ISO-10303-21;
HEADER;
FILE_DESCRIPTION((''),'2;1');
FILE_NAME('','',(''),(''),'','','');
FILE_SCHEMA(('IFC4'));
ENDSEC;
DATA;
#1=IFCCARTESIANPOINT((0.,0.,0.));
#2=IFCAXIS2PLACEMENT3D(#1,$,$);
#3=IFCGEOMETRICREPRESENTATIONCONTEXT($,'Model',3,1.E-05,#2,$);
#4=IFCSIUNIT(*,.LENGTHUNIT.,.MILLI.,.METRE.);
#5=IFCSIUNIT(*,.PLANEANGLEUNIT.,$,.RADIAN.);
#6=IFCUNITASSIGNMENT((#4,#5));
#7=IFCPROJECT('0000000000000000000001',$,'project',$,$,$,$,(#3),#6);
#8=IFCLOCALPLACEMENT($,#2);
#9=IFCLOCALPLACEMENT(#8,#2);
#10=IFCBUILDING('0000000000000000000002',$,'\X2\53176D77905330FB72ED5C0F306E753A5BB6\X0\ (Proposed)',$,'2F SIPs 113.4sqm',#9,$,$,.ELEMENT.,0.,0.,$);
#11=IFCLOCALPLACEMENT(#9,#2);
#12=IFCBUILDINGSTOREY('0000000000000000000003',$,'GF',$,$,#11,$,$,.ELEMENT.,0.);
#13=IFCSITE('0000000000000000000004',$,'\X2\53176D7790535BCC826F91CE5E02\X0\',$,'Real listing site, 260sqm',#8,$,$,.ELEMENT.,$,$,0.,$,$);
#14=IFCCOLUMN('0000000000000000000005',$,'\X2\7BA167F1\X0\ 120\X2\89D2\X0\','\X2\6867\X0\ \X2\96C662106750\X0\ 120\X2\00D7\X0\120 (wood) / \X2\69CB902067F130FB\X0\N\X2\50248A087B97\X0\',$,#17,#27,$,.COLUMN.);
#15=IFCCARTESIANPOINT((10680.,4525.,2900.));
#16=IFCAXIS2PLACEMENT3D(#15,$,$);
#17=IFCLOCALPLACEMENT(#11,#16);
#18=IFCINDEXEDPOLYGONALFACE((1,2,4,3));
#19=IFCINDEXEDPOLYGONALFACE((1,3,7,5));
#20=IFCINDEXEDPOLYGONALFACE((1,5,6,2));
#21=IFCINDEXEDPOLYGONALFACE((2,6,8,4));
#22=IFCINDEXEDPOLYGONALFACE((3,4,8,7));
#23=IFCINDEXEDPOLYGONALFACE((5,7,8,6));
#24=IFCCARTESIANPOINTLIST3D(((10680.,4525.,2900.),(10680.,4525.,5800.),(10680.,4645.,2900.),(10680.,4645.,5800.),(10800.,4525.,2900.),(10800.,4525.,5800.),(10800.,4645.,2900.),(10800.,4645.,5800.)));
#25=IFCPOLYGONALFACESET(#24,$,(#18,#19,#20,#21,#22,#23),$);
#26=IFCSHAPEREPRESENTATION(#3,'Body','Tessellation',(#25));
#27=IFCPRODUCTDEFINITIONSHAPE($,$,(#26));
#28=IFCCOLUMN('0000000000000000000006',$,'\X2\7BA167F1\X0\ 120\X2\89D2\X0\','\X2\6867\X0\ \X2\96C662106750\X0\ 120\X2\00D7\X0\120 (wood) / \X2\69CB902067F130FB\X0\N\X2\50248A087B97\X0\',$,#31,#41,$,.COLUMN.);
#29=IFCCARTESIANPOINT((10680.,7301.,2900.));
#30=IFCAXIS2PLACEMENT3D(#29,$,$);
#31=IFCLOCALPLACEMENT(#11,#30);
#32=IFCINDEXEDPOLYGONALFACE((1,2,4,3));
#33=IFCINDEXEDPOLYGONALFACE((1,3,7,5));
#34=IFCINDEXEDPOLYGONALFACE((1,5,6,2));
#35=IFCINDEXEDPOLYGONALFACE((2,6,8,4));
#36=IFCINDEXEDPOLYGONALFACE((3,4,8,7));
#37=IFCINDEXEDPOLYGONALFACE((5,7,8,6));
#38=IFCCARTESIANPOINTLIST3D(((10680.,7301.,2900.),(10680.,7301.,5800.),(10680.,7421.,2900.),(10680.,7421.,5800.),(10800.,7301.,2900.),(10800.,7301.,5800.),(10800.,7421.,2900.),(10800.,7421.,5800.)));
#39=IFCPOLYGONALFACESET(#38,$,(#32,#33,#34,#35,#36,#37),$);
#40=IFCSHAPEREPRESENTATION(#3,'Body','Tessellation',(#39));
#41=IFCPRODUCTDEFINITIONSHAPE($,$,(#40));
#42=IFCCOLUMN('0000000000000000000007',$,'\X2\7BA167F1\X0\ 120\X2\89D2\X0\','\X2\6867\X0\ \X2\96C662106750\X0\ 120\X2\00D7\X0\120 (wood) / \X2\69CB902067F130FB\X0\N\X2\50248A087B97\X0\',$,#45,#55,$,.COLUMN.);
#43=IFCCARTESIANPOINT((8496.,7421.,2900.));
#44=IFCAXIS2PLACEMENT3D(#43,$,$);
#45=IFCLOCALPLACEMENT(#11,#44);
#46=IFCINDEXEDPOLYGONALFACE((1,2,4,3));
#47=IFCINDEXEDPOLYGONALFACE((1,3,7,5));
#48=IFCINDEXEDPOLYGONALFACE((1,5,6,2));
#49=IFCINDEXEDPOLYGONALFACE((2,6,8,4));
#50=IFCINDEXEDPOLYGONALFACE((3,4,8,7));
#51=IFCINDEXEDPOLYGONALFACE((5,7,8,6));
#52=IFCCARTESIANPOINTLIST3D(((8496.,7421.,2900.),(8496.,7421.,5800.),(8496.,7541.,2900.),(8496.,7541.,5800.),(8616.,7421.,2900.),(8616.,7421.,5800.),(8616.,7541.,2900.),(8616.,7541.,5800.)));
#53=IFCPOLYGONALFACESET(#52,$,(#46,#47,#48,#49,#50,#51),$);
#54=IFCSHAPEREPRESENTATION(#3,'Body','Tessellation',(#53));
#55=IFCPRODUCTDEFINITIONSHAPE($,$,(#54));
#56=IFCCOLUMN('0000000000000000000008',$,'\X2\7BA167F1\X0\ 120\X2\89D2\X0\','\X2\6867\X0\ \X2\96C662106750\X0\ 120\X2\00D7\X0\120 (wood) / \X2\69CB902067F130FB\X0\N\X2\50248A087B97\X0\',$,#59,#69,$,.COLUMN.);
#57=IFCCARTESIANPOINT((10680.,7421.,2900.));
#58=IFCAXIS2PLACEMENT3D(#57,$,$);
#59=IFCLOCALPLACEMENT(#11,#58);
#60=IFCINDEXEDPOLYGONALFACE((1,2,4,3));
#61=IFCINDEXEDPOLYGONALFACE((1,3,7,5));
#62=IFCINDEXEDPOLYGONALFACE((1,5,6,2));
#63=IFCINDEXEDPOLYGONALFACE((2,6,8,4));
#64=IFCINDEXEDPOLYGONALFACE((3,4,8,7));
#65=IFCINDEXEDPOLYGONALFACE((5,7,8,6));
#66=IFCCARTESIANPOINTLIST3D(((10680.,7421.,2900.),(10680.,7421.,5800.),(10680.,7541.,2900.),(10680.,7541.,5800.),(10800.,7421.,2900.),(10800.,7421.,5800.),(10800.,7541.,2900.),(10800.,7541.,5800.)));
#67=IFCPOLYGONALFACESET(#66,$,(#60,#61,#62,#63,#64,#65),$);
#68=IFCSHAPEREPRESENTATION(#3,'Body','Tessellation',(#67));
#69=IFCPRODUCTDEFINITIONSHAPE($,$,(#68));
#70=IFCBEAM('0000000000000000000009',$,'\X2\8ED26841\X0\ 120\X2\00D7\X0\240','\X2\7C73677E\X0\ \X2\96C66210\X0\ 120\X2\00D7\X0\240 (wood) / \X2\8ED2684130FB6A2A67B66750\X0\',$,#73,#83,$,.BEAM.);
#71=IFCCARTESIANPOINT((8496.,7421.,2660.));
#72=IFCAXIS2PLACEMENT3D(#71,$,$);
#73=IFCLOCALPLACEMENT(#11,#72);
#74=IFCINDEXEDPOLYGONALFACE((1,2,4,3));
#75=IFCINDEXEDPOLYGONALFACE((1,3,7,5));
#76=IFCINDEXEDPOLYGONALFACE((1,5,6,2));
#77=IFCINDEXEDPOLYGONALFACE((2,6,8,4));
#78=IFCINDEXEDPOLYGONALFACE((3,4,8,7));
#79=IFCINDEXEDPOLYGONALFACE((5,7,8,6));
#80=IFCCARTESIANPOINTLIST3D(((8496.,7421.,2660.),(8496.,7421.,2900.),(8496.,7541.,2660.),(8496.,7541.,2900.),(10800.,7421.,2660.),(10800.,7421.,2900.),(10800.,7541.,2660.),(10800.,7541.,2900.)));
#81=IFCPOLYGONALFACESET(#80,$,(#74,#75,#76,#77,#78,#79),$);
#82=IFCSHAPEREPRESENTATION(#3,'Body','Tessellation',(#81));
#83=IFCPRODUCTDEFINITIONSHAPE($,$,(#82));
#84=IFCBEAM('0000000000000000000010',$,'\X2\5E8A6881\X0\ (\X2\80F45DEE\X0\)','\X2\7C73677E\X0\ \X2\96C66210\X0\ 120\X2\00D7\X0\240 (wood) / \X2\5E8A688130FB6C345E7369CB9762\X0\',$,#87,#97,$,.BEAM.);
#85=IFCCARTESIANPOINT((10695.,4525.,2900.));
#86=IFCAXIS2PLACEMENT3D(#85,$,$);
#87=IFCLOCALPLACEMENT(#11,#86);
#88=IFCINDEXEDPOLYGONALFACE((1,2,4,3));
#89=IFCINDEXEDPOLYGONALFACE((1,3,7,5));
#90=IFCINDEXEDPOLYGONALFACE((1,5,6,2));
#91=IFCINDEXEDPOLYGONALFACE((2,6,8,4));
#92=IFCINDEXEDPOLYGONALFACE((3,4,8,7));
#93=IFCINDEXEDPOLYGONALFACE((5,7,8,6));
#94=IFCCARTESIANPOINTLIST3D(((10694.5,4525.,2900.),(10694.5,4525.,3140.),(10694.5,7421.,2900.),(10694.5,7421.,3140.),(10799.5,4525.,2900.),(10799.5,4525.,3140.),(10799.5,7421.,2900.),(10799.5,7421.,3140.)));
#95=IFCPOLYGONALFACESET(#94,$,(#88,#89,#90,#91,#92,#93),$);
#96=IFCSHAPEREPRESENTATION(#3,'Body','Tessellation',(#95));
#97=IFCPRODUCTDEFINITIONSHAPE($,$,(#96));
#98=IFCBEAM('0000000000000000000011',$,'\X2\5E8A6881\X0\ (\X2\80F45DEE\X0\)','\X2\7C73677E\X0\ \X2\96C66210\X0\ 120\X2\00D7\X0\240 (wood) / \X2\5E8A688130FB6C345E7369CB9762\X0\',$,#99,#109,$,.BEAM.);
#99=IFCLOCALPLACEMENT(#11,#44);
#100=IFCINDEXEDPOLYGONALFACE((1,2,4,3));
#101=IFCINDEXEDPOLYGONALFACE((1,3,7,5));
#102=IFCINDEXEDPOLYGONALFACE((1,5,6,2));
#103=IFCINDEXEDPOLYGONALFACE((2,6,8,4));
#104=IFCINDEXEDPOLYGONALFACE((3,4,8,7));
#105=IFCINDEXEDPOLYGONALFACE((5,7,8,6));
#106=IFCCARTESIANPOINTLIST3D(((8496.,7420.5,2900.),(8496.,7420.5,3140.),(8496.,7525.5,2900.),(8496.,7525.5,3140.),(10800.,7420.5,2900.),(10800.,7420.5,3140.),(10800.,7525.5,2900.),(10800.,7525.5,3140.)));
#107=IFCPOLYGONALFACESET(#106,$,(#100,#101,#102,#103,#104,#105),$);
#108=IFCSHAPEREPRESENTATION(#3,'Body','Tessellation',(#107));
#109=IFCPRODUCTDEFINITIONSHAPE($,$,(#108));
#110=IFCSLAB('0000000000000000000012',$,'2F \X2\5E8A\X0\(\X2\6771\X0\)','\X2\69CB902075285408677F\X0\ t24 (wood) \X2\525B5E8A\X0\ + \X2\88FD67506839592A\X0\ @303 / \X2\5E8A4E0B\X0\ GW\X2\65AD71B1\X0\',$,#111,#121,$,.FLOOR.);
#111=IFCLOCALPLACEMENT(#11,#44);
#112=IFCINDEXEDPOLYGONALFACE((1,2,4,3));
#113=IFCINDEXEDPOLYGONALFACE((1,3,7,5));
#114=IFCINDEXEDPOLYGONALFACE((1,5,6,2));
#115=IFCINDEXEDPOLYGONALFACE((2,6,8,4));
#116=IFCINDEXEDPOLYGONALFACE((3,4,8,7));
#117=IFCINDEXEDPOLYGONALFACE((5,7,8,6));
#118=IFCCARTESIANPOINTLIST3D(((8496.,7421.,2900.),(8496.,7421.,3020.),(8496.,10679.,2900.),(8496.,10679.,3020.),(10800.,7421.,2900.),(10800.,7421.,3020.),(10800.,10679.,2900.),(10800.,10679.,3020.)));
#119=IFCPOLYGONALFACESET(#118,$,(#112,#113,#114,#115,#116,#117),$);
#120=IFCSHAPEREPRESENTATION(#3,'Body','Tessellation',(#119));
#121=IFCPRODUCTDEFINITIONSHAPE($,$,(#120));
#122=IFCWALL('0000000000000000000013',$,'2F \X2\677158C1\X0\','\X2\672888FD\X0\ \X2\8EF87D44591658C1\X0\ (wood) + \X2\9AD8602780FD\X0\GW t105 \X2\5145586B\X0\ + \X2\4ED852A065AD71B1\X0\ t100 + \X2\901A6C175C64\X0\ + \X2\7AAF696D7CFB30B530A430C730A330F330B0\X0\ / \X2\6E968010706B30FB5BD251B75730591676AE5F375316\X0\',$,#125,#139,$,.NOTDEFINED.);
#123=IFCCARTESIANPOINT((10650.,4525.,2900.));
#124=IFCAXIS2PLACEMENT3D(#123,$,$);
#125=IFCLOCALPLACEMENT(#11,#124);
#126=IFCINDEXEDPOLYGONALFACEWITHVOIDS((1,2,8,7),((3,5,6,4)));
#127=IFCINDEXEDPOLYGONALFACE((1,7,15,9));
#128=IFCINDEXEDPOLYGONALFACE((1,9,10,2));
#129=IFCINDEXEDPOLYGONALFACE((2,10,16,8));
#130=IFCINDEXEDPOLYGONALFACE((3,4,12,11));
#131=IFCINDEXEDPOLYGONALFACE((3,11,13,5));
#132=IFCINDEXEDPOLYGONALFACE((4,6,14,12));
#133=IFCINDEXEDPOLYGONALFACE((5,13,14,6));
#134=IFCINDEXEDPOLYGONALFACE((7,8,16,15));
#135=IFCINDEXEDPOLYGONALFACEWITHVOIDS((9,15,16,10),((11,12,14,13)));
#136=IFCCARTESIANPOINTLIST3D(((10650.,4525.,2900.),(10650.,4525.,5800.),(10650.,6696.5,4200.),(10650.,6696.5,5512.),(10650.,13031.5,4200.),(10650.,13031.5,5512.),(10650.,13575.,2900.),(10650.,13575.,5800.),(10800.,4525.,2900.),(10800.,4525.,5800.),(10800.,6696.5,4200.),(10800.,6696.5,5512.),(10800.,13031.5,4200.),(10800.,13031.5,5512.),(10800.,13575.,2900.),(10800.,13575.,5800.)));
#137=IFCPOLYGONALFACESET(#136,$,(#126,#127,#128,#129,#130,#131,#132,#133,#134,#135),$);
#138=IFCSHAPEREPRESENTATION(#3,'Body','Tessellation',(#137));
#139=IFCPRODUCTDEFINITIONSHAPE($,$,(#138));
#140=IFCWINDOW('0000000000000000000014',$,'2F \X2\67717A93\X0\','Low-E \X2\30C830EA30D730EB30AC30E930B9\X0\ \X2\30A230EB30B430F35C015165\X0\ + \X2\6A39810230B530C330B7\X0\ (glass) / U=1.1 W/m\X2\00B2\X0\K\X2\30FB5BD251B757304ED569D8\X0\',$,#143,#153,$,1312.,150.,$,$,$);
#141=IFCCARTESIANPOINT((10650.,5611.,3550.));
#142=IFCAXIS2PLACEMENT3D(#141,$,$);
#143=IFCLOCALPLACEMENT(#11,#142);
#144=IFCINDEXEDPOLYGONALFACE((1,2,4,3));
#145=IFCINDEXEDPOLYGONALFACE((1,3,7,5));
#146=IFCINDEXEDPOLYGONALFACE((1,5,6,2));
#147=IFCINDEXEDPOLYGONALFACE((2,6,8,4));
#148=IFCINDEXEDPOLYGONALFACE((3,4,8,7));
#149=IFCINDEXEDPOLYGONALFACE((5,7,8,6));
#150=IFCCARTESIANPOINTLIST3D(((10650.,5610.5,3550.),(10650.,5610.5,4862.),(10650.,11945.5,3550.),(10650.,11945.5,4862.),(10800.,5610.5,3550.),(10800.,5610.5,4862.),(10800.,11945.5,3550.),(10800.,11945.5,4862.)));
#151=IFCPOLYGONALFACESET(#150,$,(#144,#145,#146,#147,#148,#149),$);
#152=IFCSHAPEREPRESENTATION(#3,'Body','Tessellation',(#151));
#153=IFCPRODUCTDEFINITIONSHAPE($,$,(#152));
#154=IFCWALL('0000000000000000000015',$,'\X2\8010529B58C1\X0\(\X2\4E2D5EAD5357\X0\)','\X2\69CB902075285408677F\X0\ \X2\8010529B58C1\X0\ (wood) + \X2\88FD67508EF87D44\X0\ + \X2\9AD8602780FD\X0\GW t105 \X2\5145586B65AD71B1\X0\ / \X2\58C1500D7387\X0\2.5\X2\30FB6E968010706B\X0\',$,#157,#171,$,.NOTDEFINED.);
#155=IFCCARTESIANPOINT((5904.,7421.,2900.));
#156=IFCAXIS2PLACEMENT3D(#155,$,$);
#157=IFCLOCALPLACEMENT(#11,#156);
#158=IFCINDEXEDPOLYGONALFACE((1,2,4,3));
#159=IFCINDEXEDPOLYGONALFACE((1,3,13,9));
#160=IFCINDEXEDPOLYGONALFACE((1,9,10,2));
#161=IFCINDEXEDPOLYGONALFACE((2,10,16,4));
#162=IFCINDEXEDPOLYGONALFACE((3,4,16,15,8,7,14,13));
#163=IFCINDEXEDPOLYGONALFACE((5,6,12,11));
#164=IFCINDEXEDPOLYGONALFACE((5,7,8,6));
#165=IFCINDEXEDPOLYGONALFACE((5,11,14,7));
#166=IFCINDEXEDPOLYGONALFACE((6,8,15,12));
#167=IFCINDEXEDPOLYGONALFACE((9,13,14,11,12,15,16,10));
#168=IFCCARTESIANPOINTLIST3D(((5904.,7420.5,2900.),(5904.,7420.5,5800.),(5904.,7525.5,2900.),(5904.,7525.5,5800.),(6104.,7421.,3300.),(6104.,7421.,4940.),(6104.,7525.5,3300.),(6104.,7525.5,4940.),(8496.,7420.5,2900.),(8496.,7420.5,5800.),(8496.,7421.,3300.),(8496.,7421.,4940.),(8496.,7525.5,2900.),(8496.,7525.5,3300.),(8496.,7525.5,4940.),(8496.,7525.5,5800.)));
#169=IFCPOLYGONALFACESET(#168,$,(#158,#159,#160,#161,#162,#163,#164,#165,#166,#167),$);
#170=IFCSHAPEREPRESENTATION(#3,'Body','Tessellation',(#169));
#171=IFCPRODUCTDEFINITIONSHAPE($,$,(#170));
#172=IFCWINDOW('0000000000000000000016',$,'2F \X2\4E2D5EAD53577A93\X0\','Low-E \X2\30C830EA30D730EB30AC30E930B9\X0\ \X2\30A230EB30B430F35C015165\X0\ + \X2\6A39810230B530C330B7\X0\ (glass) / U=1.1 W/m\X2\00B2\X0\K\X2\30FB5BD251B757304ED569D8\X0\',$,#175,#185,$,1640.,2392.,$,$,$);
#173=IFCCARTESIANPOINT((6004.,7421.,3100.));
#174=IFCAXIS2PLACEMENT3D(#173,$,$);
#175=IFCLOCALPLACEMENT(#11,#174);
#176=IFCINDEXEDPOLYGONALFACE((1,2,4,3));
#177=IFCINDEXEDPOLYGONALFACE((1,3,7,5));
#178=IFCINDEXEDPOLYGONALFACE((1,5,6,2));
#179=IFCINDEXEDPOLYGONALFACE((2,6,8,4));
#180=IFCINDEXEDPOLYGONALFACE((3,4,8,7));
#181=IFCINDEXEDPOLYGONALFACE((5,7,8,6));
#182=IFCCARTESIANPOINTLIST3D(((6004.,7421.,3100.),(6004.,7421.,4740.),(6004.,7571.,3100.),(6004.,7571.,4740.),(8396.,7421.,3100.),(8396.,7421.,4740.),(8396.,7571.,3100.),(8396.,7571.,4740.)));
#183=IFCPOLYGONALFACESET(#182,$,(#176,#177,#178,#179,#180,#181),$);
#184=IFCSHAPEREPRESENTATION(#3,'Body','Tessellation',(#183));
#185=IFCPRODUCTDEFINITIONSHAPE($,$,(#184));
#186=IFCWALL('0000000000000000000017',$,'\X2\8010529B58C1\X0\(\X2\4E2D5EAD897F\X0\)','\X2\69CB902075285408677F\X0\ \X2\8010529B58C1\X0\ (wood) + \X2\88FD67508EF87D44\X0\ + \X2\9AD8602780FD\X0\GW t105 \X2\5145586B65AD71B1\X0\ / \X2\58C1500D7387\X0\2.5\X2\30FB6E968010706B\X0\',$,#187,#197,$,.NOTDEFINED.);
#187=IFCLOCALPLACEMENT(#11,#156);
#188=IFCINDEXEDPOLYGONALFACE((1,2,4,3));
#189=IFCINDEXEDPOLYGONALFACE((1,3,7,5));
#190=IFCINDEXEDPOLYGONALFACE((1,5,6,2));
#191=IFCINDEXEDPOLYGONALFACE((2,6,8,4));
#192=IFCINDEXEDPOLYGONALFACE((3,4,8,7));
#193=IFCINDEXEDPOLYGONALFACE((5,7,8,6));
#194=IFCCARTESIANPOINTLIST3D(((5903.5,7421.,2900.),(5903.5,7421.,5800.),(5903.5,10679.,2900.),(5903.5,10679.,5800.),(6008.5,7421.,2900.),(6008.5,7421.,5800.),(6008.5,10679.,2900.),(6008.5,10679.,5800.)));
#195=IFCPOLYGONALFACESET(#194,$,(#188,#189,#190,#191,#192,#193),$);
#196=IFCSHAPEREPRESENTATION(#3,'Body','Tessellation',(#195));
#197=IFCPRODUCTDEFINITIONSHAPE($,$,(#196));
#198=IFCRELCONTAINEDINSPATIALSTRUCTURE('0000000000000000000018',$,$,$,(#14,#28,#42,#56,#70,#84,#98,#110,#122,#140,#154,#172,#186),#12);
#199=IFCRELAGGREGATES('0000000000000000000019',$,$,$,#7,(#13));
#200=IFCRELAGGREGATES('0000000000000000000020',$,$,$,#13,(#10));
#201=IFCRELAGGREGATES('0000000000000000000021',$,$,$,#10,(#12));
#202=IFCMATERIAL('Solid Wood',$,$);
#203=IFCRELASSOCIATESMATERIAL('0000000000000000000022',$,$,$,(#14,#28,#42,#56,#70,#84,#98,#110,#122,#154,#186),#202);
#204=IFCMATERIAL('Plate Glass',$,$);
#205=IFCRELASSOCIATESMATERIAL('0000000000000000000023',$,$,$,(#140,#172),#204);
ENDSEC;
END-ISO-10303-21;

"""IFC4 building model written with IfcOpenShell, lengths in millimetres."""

from ifc_helpers import new_model, si_unit, frame, frame_2d, origin, place, context, project, spatial, rectangle, extrude, material, element, fill, save


model = new_model("IFC4")

# Units and contexts
model_context = context("Model", 3, precision=1e-05, world=origin())
ifc_project = project(units=[si_unit("LENGTHUNIT", "METRE", prefix="MILLI"), si_unit("PLANEANGLEUNIT", "RADIAN")], contexts=[model_context])

# Site, building, storey
site_placement = place(None, origin())
site = spatial("IfcSite", under=ifc_project, at=site_placement, Name="北海道富良野市", ObjectType="Real listing site, 260sqm", CompositionType="ELEMENT", RefElevation=0.0)
building_placement = place(site_placement, origin())
building = spatial("IfcBuilding", under=site, at=building_placement, Name="北海道・狭小の町家 (Proposed)", ObjectType="2F SIPs 113.4sqm", CompositionType="ELEMENT", ElevationOfRefHeight=0.0, ElevationOfTerrain=0.0)
storey_placement = place(building_placement, origin())
storey = spatial("IfcBuildingStorey", under=building, at=storey_placement, Name="GF", CompositionType="ELEMENT", Elevation=0.0)

# Columns
ifc_material_1 = material(Name="Solid Wood")
column_1_placement = place(storey_placement, frame((10680.0, 4525.0, 2900.0)))
element("IfcColumn", 1, at=column_1_placement, inside=storey, material=ifc_material_1, Name="管柱 120角", Description="桧 集成材 120×120 (wood) / 構造柱・N値計算", PredefinedType="COLUMN", context=model_context, shape_type="SweptSolid", body=[
    extrude(rectangle(XDim=120.0, YDim=120.0, at=frame_2d((60.0, 60.0))), frame((10680.0, 4525.0, 2900.0)), (0.0, 0.0, 1.0), 2900.0),
])
column_2_placement = place(storey_placement, frame((10680.0, 7301.0, 2900.0)))
element("IfcColumn", 2, at=column_2_placement, inside=storey, material=ifc_material_1, Name="管柱 120角", Description="桧 集成材 120×120 (wood) / 構造柱・N値計算", PredefinedType="COLUMN", context=model_context, shape_type="SweptSolid", body=[
    extrude(rectangle(XDim=120.0, YDim=120.0, at=frame_2d((60.0, 60.0))), frame((10680.0, 7301.0, 2900.0)), (0.0, 0.0, 1.0), 2900.0),
])
column_3_placement = place(storey_placement, frame((8496.0, 7421.0, 2900.0)))
element("IfcColumn", 3, at=column_3_placement, inside=storey, material=ifc_material_1, Name="管柱 120角", Description="桧 集成材 120×120 (wood) / 構造柱・N値計算", PredefinedType="COLUMN", context=model_context, shape_type="SweptSolid", body=[
    extrude(rectangle(XDim=120.0, YDim=120.0, at=frame_2d((60.0, 60.0))), frame((8496.0, 7421.0, 2900.0)), (0.0, 0.0, 1.0), 2900.0),
])
column_4_placement = place(storey_placement, frame((10680.0, 7421.0, 2900.0)))
element("IfcColumn", 4, at=column_4_placement, inside=storey, material=ifc_material_1, Name="管柱 120角", Description="桧 集成材 120×120 (wood) / 構造柱・N値計算", PredefinedType="COLUMN", context=model_context, shape_type="SweptSolid", body=[
    extrude(rectangle(XDim=120.0, YDim=120.0, at=frame_2d((60.0, 60.0))), frame((10680.0, 7421.0, 2900.0)), (0.0, 0.0, 1.0), 2900.0),
])

# Beams
beam_1_placement = place(storey_placement, frame((8496.0, 7421.0, 2660.0)))
element("IfcBeam", 5, at=beam_1_placement, inside=storey, material=ifc_material_1, Name="軒桁 120×240", Description="米松 集成 120×240 (wood) / 軒桁・横架材", PredefinedType="BEAM", context=model_context, shape_type="SweptSolid", body=[
    extrude(rectangle(XDim=2304.0, YDim=120.0, at=frame_2d((1152.0, 60.0))), frame((8496.0, 7421.0, 2660.0)), (0.0, 0.0, 1.0), 240.0),
])
beam_2_placement = place(storey_placement, frame((10695.0, 4525.0, 2900.0)))
element("IfcBeam", 6, at=beam_2_placement, inside=storey, material=ifc_material_1, Name="床梁 (胴差)", Description="米松 集成 120×240 (wood) / 床梁・水平構面", PredefinedType="BEAM", context=model_context, shape_type="SweptSolid", body=[
    extrude(rectangle(XDim=105.0, YDim=2896.0, at=frame_2d((52.0, 1448.0))), frame((10695.0, 4525.0, 2900.0)), (0.0, 0.0, 1.0), 240.0),
])
beam_3_placement = place(storey_placement, frame((8496.0, 7421.0, 2900.0)))
element("IfcBeam", 7, at=beam_3_placement, inside=storey, material=ifc_material_1, Name="床梁 (胴差)", Description="米松 集成 120×240 (wood) / 床梁・水平構面", PredefinedType="BEAM", context=model_context, shape_type="SweptSolid", body=[
    extrude(rectangle(XDim=2304.0, YDim=105.0, at=frame_2d((1152.0, 52.0))), frame((8496.0, 7421.0, 2900.0)), (0.0, 0.0, 1.0), 240.0),
])

# Slab
slab_placement = place(storey_placement, frame((8496.0, 7421.0, 2900.0)))
element("IfcSlab", 8, at=slab_placement, inside=storey, material=ifc_material_1, Name="2F 床(東)", Description="構造用合板 t24 (wood) 剛床 + 製材根太 @303 / 床下 GW断熱", PredefinedType="FLOOR", context=model_context, shape_type="SweptSolid", body=[
    extrude(rectangle(XDim=2304.0, YDim=3258.0, at=frame_2d((1152.0, 1629.0))), frame((8496.0, 7421.0, 2900.0)), (0.0, 0.0, 1.0), 120.0),
])

# Walls, openings, windows
wall_1_placement = place(storey_placement, frame((10650.0, 4525.0, 2900.0)))
wall_1 = element("IfcWall", 9, at=wall_1_placement, inside=storey, material=ifc_material_1, Name="2F 東壁", Description="木製 軸組外壁 (wood) + 高性能GW t105 充填 + 付加断熱 t100 + 通気層 + 窯業系サイディング / 準耐火・寒冷地外皮強化", PredefinedType="NOTDEFINED", context=model_context, shape_type="SweptSolid", body=[
    extrude(rectangle(XDim=150.0, YDim=9050.0, at=frame_2d((75.0, 4525.0))), frame((10650.0, 4525.0, 2900.0)), (0.0, 0.0, 1.0), 2900.0),
])
opening_1_placement = place(storey_placement, frame((10650.0, 5611.0, 3550.0)))
opening_1 = element("IfcOpeningElement", 10, at=opening_1_placement, cuts=wall_1, PredefinedType="NOTDEFINED", context=model_context, shape_type="SweptSolid", body=[
    extrude(rectangle(XDim=150.0, YDim=6335.0, at=frame_2d((75.0, 3167.0))), frame((10650.0, 5611.0, 3550.0)), (0.0, 0.0, 1.0), 1312.0),
])
ifc_material_2 = material(Name="Plate Glass")
window_1_placement = place(storey_placement, frame((10650.0, 5611.0, 3550.0)))
window_1 = element("IfcWindow", 11, at=window_1_placement, inside=storey, material=ifc_material_2, Name="2F 東窓", Description="Low-E トリプルガラス アルゴン封入 + 樹脂サッシ (glass) / U=1.1 W/m²K・寒冷地仕様", OverallHeight=1312.0, OverallWidth=150.0, context=model_context, shape_type="SweptSolid", body=[
    extrude(rectangle(XDim=150.0, YDim=6335.0, at=frame_2d((75.0, 3167.0))), frame((10650.0, 5611.0, 3550.0)), (0.0, 0.0, 1.0), 1312.0),
])
fill(opening_1, window_1)
wall_2_placement = place(storey_placement, frame((5904.0, 7421.0, 2900.0)))
wall_2 = element("IfcWall", 12, at=wall_2_placement, inside=storey, material=ifc_material_1, Name="耐力壁(中庭南)", Description="構造用合板 耐力壁 (wood) + 製材軸組 + 高性能GW t105 充填断熱 / 壁倍率2.5・準耐火", PredefinedType="NOTDEFINED", context=model_context, shape_type="SweptSolid", body=[
    extrude(rectangle(XDim=2592.0, YDim=105.0, at=frame_2d((1296.0, 52.0))), frame((5904.0, 7421.0, 2900.0)), (0.0, 0.0, 1.0), 2900.0),
])
opening_2_placement = place(storey_placement, frame((6004.0, 7421.0, 3100.0)))
opening_2 = element("IfcOpeningElement", 13, at=opening_2_placement, cuts=wall_2, PredefinedType="NOTDEFINED", context=model_context, shape_type="SweptSolid", body=[
    extrude(rectangle(XDim=2392.0, YDim=150.0, at=frame_2d((1196.0, 75.0))), frame((6004.0, 7421.0, 3100.0)), (0.0, 0.0, 1.0), 1640.0),
])
window_2_placement = place(storey_placement, frame((6004.0, 7421.0, 3100.0)))
window_2 = element("IfcWindow", 14, at=window_2_placement, inside=storey, material=ifc_material_2, Name="2F 中庭南窓", Description="Low-E トリプルガラス アルゴン封入 + 樹脂サッシ (glass) / U=1.1 W/m²K・寒冷地仕様", OverallHeight=1640.0, OverallWidth=2392.0, context=model_context, shape_type="SweptSolid", body=[
    extrude(rectangle(XDim=2392.0, YDim=150.0, at=frame_2d((1196.0, 75.0))), frame((6004.0, 7421.0, 3100.0)), (0.0, 0.0, 1.0), 1640.0),
])
fill(opening_2, window_2)

# Wall
wall_3_placement = place(storey_placement, frame((5904.0, 7421.0, 2900.0)))
element("IfcWall", 15, at=wall_3_placement, inside=storey, material=ifc_material_1, Name="耐力壁(中庭西)", Description="構造用合板 耐力壁 (wood) + 製材軸組 + 高性能GW t105 充填断熱 / 壁倍率2.5・準耐火", PredefinedType="NOTDEFINED", context=model_context, shape_type="SweptSolid", body=[
    extrude(rectangle(XDim=105.0, YDim=3258.0, at=frame_2d((52.0, 1629.0))), frame((5904.0, 7421.0, 2900.0)), (0.0, 0.0, 1.0), 2900.0),
])

save(model, "model.ifc")
